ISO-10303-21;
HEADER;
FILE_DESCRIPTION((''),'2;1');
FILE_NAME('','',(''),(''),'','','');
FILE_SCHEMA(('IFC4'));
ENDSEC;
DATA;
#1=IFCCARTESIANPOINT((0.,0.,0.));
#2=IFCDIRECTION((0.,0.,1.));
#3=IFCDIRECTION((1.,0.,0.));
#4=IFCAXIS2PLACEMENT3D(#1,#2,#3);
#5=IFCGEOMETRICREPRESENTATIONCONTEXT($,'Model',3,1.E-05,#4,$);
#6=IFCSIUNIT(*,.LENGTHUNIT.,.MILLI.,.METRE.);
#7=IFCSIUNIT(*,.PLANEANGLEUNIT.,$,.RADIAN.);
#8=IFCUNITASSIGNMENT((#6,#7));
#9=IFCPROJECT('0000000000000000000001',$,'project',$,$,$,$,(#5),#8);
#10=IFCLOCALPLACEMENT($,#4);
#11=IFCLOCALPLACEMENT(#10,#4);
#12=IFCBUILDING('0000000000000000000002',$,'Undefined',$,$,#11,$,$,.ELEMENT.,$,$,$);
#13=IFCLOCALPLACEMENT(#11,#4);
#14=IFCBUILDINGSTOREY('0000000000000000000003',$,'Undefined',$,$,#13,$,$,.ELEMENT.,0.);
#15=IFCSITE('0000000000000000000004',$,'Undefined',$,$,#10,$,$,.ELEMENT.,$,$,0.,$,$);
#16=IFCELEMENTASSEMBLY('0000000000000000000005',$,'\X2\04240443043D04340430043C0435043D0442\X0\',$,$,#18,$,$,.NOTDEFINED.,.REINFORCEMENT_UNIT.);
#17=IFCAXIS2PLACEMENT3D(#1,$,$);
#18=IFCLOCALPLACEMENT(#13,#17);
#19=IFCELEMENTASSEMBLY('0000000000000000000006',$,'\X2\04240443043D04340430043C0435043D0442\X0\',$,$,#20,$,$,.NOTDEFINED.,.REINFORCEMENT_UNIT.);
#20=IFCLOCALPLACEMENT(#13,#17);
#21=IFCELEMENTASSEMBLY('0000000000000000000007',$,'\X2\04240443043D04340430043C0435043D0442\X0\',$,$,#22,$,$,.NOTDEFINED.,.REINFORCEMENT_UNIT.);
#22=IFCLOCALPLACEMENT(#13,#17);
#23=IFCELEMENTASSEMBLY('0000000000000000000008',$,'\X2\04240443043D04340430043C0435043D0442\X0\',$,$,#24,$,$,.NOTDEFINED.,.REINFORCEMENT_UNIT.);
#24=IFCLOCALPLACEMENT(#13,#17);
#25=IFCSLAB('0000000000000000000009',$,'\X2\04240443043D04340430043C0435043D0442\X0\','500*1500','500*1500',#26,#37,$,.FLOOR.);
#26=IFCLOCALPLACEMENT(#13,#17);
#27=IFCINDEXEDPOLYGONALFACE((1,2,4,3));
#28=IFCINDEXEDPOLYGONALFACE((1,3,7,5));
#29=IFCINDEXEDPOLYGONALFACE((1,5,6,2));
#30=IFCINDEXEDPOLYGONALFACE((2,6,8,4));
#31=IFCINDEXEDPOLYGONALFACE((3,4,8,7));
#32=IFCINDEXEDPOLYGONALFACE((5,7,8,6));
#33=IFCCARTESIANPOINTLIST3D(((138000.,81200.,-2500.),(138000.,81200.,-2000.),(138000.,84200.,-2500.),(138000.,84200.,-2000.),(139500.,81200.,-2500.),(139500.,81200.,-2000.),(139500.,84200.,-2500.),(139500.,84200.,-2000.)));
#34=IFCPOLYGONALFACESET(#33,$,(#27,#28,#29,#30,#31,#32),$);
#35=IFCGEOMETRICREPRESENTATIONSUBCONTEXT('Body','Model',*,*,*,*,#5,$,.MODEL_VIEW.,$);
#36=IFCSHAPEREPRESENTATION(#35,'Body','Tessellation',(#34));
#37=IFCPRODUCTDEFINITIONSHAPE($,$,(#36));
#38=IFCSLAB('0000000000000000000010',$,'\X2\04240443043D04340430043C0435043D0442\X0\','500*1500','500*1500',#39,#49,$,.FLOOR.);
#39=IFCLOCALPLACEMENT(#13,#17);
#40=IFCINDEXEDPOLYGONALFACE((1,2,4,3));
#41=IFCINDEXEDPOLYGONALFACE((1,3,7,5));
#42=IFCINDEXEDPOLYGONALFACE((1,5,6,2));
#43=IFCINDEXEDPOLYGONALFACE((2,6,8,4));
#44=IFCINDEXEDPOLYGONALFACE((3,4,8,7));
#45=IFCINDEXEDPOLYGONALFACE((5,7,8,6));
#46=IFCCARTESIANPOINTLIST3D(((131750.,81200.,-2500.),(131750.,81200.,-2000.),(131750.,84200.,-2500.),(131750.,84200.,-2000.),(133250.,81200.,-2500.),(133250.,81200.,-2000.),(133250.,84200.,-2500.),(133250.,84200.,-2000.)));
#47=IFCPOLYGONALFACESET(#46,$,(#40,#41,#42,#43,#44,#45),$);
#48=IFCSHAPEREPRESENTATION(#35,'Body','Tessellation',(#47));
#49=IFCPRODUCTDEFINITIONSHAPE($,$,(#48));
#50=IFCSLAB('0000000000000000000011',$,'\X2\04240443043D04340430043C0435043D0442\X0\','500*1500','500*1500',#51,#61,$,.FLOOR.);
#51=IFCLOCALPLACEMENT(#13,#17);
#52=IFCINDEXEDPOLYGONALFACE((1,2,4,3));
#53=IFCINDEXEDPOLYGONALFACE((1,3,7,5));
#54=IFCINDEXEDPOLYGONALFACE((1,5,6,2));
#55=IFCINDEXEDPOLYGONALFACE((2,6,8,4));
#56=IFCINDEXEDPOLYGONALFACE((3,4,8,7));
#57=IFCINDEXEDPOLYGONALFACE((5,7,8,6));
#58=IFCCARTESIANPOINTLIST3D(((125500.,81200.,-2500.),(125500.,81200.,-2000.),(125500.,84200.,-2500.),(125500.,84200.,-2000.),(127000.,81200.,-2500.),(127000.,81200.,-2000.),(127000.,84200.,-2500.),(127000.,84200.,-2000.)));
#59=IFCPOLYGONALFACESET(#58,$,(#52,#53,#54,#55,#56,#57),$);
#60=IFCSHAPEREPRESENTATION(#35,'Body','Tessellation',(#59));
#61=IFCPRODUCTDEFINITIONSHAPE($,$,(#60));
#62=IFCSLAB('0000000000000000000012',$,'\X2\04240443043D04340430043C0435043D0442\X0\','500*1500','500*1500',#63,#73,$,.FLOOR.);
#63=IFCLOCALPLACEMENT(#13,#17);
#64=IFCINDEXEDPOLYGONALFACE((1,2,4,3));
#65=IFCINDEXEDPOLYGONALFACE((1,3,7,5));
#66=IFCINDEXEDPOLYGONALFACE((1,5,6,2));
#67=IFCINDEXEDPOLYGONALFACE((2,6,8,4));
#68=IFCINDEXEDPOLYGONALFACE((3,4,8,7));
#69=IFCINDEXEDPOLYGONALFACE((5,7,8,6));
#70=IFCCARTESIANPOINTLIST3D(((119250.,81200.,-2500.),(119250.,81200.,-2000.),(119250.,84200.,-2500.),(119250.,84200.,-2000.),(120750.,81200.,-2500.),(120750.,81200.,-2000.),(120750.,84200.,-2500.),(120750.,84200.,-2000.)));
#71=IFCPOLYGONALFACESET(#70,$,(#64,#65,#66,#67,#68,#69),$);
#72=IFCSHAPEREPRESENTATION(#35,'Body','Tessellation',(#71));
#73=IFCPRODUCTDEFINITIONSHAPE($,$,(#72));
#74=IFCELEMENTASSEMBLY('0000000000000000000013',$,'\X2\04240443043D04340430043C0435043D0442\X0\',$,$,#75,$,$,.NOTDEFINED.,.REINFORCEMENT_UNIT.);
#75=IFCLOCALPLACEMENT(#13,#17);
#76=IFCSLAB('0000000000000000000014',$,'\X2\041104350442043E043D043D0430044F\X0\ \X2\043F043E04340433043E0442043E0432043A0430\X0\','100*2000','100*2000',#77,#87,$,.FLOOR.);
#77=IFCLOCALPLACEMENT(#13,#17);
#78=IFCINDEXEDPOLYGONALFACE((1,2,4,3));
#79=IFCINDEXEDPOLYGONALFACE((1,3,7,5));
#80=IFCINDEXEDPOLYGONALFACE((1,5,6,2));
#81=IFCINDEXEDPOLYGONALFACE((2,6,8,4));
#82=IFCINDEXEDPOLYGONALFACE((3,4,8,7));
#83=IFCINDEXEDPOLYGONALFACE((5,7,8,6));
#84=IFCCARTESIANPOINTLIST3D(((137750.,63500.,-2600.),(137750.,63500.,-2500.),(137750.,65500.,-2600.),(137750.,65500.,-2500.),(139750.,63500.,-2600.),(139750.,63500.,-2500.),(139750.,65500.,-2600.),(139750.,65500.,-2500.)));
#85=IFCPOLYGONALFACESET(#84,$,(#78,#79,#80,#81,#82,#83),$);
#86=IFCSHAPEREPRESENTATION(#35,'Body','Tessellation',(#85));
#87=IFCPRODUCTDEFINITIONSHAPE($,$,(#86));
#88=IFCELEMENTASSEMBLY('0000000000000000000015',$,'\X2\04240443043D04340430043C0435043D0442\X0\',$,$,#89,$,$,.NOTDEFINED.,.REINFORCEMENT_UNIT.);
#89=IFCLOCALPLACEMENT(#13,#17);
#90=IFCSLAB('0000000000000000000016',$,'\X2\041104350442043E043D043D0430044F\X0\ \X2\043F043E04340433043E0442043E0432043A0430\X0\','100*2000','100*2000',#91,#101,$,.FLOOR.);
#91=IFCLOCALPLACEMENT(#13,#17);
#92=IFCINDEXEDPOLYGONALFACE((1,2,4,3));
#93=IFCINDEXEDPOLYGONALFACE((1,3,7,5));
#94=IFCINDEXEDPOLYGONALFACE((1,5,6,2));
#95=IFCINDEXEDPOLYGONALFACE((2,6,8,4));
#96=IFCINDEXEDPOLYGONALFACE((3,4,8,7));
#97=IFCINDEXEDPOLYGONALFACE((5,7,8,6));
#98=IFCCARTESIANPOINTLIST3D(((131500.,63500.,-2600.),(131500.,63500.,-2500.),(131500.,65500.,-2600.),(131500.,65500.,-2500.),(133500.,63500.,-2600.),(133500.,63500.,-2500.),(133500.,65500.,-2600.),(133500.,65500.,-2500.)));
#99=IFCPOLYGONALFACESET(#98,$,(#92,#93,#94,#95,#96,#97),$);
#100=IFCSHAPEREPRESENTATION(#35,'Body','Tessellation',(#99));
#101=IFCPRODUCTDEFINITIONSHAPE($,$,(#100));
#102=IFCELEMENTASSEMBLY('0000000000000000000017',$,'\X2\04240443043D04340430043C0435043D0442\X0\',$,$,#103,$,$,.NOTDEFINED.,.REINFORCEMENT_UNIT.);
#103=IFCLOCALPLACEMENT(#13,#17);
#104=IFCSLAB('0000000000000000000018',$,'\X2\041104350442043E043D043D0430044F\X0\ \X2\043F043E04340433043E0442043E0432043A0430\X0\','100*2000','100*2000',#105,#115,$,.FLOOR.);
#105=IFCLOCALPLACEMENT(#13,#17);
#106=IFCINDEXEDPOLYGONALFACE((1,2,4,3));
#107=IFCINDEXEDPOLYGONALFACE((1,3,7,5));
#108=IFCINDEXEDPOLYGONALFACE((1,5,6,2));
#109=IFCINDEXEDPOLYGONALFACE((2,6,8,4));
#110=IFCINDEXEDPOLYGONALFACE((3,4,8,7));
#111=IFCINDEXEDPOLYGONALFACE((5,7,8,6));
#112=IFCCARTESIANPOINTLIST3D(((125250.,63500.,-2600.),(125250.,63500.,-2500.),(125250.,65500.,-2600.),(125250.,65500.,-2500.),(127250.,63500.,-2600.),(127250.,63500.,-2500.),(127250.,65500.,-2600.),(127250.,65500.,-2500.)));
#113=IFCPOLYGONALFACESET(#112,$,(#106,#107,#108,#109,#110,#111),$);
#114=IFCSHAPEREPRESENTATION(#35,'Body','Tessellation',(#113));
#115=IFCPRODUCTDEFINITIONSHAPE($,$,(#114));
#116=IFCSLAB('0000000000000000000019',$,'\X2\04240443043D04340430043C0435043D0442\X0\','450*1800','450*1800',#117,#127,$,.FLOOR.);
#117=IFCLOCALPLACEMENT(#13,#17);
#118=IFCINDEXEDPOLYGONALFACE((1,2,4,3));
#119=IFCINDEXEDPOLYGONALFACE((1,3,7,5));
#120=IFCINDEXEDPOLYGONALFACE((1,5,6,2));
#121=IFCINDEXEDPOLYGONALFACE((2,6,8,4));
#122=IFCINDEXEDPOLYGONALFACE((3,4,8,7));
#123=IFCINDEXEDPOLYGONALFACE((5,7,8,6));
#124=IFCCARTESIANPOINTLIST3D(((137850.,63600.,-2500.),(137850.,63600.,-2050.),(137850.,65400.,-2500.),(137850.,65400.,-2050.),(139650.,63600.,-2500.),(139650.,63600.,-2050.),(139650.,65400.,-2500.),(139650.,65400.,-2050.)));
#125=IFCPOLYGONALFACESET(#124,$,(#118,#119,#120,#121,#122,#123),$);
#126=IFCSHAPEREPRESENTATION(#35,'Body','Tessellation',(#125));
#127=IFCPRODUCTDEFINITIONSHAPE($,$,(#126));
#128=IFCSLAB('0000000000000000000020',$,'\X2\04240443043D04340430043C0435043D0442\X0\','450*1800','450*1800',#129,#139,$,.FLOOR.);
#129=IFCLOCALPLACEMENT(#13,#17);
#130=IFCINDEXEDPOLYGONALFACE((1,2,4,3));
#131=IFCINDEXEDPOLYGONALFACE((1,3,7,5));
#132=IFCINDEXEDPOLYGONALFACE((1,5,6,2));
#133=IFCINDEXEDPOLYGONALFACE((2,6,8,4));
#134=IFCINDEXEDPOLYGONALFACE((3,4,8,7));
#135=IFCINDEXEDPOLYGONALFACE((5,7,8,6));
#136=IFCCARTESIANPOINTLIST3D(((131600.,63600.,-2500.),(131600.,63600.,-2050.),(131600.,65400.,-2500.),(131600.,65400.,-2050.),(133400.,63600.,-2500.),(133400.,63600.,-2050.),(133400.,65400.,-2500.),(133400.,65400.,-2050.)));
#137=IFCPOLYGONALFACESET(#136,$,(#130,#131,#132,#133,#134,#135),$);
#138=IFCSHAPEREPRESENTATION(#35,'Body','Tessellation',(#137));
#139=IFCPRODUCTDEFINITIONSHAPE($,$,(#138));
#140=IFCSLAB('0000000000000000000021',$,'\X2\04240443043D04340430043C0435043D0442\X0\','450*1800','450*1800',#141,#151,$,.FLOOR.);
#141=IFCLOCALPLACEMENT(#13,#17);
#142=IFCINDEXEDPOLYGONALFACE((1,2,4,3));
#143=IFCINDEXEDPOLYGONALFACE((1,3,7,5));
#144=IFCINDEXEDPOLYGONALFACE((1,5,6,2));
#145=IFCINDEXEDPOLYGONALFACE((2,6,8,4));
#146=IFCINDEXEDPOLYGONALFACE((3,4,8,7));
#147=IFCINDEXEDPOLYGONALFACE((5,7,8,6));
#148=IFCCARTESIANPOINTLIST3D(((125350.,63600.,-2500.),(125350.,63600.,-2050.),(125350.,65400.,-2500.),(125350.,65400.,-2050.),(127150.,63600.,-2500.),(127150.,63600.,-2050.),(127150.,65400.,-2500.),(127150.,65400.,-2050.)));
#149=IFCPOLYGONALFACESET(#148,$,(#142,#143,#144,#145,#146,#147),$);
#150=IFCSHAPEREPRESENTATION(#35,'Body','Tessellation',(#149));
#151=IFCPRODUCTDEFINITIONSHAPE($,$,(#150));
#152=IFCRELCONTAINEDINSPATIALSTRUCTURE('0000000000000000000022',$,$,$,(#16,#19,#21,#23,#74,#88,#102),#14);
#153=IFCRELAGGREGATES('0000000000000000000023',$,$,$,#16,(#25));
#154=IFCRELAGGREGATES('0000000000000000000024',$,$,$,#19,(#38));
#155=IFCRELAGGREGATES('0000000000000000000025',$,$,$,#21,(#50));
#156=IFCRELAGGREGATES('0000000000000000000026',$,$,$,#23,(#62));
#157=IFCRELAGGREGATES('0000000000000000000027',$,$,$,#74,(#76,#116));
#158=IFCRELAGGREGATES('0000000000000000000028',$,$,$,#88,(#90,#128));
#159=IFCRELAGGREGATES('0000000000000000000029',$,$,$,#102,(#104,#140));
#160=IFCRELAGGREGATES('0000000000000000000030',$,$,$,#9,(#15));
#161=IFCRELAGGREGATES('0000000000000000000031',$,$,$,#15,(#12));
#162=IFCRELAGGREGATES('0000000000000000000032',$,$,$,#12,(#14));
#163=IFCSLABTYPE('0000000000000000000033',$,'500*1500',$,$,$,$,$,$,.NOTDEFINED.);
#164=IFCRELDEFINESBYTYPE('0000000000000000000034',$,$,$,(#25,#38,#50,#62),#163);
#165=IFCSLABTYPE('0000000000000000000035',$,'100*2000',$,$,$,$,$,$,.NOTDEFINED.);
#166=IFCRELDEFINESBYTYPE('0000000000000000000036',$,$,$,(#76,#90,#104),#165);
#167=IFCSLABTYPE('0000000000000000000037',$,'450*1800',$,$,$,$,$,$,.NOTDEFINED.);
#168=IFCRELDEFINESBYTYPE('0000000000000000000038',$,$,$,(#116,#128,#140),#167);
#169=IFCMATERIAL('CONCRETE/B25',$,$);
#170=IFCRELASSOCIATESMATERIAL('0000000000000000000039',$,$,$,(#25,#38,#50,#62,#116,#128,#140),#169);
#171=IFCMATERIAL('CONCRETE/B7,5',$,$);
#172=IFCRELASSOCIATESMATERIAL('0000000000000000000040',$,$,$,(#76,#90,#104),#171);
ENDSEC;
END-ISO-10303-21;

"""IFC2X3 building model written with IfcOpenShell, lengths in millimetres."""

from ifc_helpers import new_model, si_unit, frame, origin_with_axes, place, context, subcontext, project, spatial, polyline, outline, extrude, material, type_object, element, aggregate, save


model = new_model("IFC2X3")

# Units and contexts
model_context = context("Model", 3, precision=1e-05, world=origin_with_axes())
body_context = subcontext(model_context, "Body", "Model", "MODEL_VIEW")
ifc_project = project(units=[si_unit("LENGTHUNIT", "METRE", prefix="MILLI"), si_unit("PLANEANGLEUNIT", "RADIAN")], contexts=[model_context])

# Site, building, storey
site_placement = place(None, origin_with_axes())
site = spatial("IfcSite", under=ifc_project, at=site_placement, Name="Undefined", CompositionType="ELEMENT", RefElevation=0.0)
building_placement = place(site_placement, origin_with_axes())
building = spatial("IfcBuilding", under=site, at=building_placement, Name="Undefined", CompositionType="ELEMENT")
storey_placement = place(building_placement, origin_with_axes())
storey = spatial("IfcBuildingStorey", under=building, at=storey_placement, Name="Undefined", CompositionType="ELEMENT", Elevation=0.0)

# Element assemblies
assembly_1_placement = place(storey_placement, origin_with_axes())
assembly_1 = element("IfcElementAssembly", 1, at=assembly_1_placement, inside=storey, Name="Фундамент", AssemblyPlace="NOTDEFINED", PredefinedType="REINFORCEMENT_UNIT")
ifc_material_1 = material(Name="CONCRETE/B25")
assembly_2_placement = place(storey_placement, origin_with_axes())
assembly_2 = element("IfcElementAssembly", 2, at=assembly_2_placement, inside=storey, Name="Фундамент", AssemblyPlace="NOTDEFINED", PredefinedType="REINFORCEMENT_UNIT")
assembly_3_placement = place(storey_placement, origin_with_axes())
assembly_3 = element("IfcElementAssembly", 3, at=assembly_3_placement, inside=storey, Name="Фундамент", AssemblyPlace="NOTDEFINED", PredefinedType="REINFORCEMENT_UNIT")
assembly_4_placement = place(storey_placement, origin_with_axes())
assembly_4 = element("IfcElementAssembly", 4, at=assembly_4_placement, inside=storey, Name="Фундамент", AssemblyPlace="NOTDEFINED", PredefinedType="REINFORCEMENT_UNIT")

# Slabs
ifc_material_2 = material(Name="CONCRETE/B7,5")
slab_type_1 = type_object("IfcSlabType", Name="500*1500", PredefinedType="NOTDEFINED")
slab_1_placement = place(assembly_1_placement, frame((138000.0, 84200.0, -2250.0), z_axis=(0.0, 0.0, 1.0), x_axis=(0.0, -1.0, 0.0)))
slab_1 = element("IfcSlab", 5, at=slab_1_placement, type_object=slab_type_1, material=ifc_material_1, Name="Фундамент", Description="500*1500", ObjectType="500*1500", PredefinedType="FLOOR", context=body_context, shape_type="SweptSolid", body=[
    extrude(outline(polyline([(0.0, 0.0), (3000.0, 0.0), (3000.0, 1500.0), (0.0, 1500.0), (0.0, 0.0)])), frame((0.0, 0.0, -250.0), z_axis=(0.0, 0.0, 1.0), x_axis=(1.0, 0.0, 0.0)), (0.0, 0.0, 1.0), 500.0),
])
aggregate(assembly_1, [slab_1])
slab_2_placement = place(assembly_2_placement, frame((131750.0, 84200.0, -2250.0), z_axis=(0.0, 0.0, 1.0), x_axis=(0.0, -1.0, 0.0)))
slab_2 = element("IfcSlab", 6, at=slab_2_placement, type_object=slab_type_1, material=ifc_material_1, Name="Фундамент", Description="500*1500", ObjectType="500*1500", PredefinedType="FLOOR", context=body_context, shape_type="SweptSolid", body=[
    extrude(outline(polyline([(0.0, 0.0), (3000.0, 0.0), (3000.0, 1500.0), (0.0, 1500.0), (0.0, 0.0)])), frame((0.0, 0.0, -250.0), z_axis=(0.0, 0.0, 1.0), x_axis=(1.0, 0.0, 0.0)), (0.0, 0.0, 1.0), 500.0),
])
aggregate(assembly_2, [slab_2])
slab_3_placement = place(assembly_3_placement, frame((125500.0, 84200.0, -2250.0), z_axis=(0.0, 0.0, 1.0), x_axis=(0.0, -1.0, 0.0)))
slab_3 = element("IfcSlab", 7, at=slab_3_placement, type_object=slab_type_1, material=ifc_material_1, Name="Фундамент", Description="500*1500", ObjectType="500*1500", PredefinedType="FLOOR", context=body_context, shape_type="SweptSolid", body=[
    extrude(outline(polyline([(0.0, 0.0), (3000.0, 0.0), (3000.0, 1500.0), (0.0, 1500.0), (0.0, 0.0)])), frame((0.0, 0.0, -250.0), z_axis=(0.0, 0.0, 1.0), x_axis=(1.0, 0.0, 0.0)), (0.0, 0.0, 1.0), 500.0),
])
aggregate(assembly_3, [slab_3])
slab_4_placement = place(assembly_4_placement, frame((119250.0, 84200.0, -2250.0), z_axis=(0.0, 0.0, 1.0), x_axis=(0.0, -1.0, 0.0)))
slab_4 = element("IfcSlab", 8, at=slab_4_placement, type_object=slab_type_1, material=ifc_material_1, Name="Фундамент", Description="500*1500", ObjectType="500*1500", PredefinedType="FLOOR", context=body_context, shape_type="SweptSolid", body=[
    extrude(outline(polyline([(0.0, 0.0), (3000.0, 0.0), (3000.0, 1500.0), (0.0, 1500.0), (0.0, 0.0)])), frame((0.0, 0.0, -250.0), z_axis=(0.0, 0.0, 1.0), x_axis=(1.0, 0.0, 0.0)), (0.0, 0.0, 1.0), 500.0),
])
aggregate(assembly_4, [slab_4])

# Element assemblies, slabs
assembly_5_placement = place(storey_placement, origin_with_axes())
assembly_5 = element("IfcElementAssembly", 9, at=assembly_5_placement, inside=storey, Name="Фундамент", AssemblyPlace="NOTDEFINED", PredefinedType="REINFORCEMENT_UNIT")
slab_type_2 = type_object("IfcSlabType", Name="100*2000", PredefinedType="NOTDEFINED")
slab_5_placement = place(assembly_5_placement, frame((137750.0, 65500.0, -2550.0), z_axis=(0.0, 0.0, 1.0), x_axis=(0.0, -1.0, 0.0)))
slab_5 = element("IfcSlab", 10, at=slab_5_placement, type_object=slab_type_2, material=ifc_material_2, Name="Бетонная подготовка", Description="100*2000", ObjectType="100*2000", PredefinedType="FLOOR", context=body_context, shape_type="SweptSolid", body=[
    extrude(outline(polyline([(0.0, 0.0), (2000.0, 0.0), (2000.0, 2000.0), (0.0, 2000.0), (0.0, 0.0)])), frame((0.0, 0.0, -50.0), z_axis=(0.0, 0.0, 1.0), x_axis=(1.0, 0.0, 0.0)), (0.0, 0.0, 1.0), 100.0),
])
assembly_6_placement = place(storey_placement, origin_with_axes())
assembly_6 = element("IfcElementAssembly", 11, at=assembly_6_placement, inside=storey, Name="Фундамент", AssemblyPlace="NOTDEFINED", PredefinedType="REINFORCEMENT_UNIT")
slab_6_placement = place(assembly_6_placement, frame((131500.0, 65500.0, -2550.0), z_axis=(0.0, 0.0, 1.0), x_axis=(0.0, -1.0, 0.0)))
slab_6 = element("IfcSlab", 12, at=slab_6_placement, type_object=slab_type_2, material=ifc_material_2, Name="Бетонная подготовка", Description="100*2000", ObjectType="100*2000", PredefinedType="FLOOR", context=body_context, shape_type="SweptSolid", body=[
    extrude(outline(polyline([(0.0, 0.0), (2000.0, 0.0), (2000.0, 2000.0), (0.0, 2000.0), (0.0, 0.0)])), frame((0.0, 0.0, -50.0), z_axis=(0.0, 0.0, 1.0), x_axis=(1.0, 0.0, 0.0)), (0.0, 0.0, 1.0), 100.0),
])
assembly_7_placement = place(storey_placement, origin_with_axes())
assembly_7 = element("IfcElementAssembly", 13, at=assembly_7_placement, inside=storey, Name="Фундамент", AssemblyPlace="NOTDEFINED", PredefinedType="REINFORCEMENT_UNIT")
slab_7_placement = place(assembly_7_placement, frame((125250.0, 65500.0, -2550.0), z_axis=(0.0, 0.0, 1.0), x_axis=(0.0, -1.0, 0.0)))
slab_7 = element("IfcSlab", 14, at=slab_7_placement, type_object=slab_type_2, material=ifc_material_2, Name="Бетонная подготовка", Description="100*2000", ObjectType="100*2000", PredefinedType="FLOOR", context=body_context, shape_type="SweptSolid", body=[
    extrude(outline(polyline([(0.0, 0.0), (2000.0, 0.0), (2000.0, 2000.0), (0.0, 2000.0), (0.0, 0.0)])), frame((0.0, 0.0, -50.0), z_axis=(0.0, 0.0, 1.0), x_axis=(1.0, 0.0, 0.0)), (0.0, 0.0, 1.0), 100.0),
])

# Slabs
slab_type_3 = type_object("IfcSlabType", Name="450*1800", PredefinedType="NOTDEFINED")
slab_8_placement = place(assembly_5_placement, frame((137850.0, 65400.0, -2275.0), z_axis=(0.0, 0.0, 1.0), x_axis=(0.0, -1.0, 0.0)))
slab_8 = element("IfcSlab", 15, at=slab_8_placement, type_object=slab_type_3, material=ifc_material_1, Name="Фундамент", Description="450*1800", ObjectType="450*1800", PredefinedType="FLOOR", context=body_context, shape_type="SweptSolid", body=[
    extrude(outline(polyline([(0.0, 0.0), (1800.0, 0.0), (1800.0, 1800.0), (0.0, 1800.0), (0.0, 0.0)])), frame((0.0, 0.0, -225.0), z_axis=(0.0, 0.0, 1.0), x_axis=(1.0, 0.0, 0.0)), (0.0, 0.0, 1.0), 450.0),
])
aggregate(assembly_5, [slab_5, slab_8])
slab_9_placement = place(assembly_6_placement, frame((131600.0, 65400.0, -2275.0), z_axis=(0.0, 0.0, 1.0), x_axis=(0.0, -1.0, 0.0)))
slab_9 = element("IfcSlab", 16, at=slab_9_placement, type_object=slab_type_3, material=ifc_material_1, Name="Фундамент", Description="450*1800", ObjectType="450*1800", PredefinedType="FLOOR", context=body_context, shape_type="SweptSolid", body=[
    extrude(outline(polyline([(0.0, 0.0), (1800.0, 0.0), (1800.0, 1800.0), (0.0, 1800.0), (0.0, 0.0)])), frame((0.0, 0.0, -225.0), z_axis=(0.0, 0.0, 1.0), x_axis=(1.0, 0.0, 0.0)), (0.0, 0.0, 1.0), 450.0),
])
aggregate(assembly_6, [slab_6, slab_9])
slab_10_placement = place(assembly_7_placement, frame((125350.0, 65400.0, -2275.0), z_axis=(0.0, 0.0, 1.0), x_axis=(0.0, -1.0, 0.0)))
slab_10 = element("IfcSlab", 17, at=slab_10_placement, type_object=slab_type_3, material=ifc_material_1, Name="Фундамент", Description="450*1800", ObjectType="450*1800", PredefinedType="FLOOR", context=body_context, shape_type="SweptSolid", body=[
    extrude(outline(polyline([(0.0, 0.0), (1800.0, 0.0), (1800.0, 1800.0), (0.0, 1800.0), (0.0, 0.0)])), frame((0.0, 0.0, -225.0), z_axis=(0.0, 0.0, 1.0), x_axis=(1.0, 0.0, 0.0)), (0.0, 0.0, 1.0), 450.0),
])
aggregate(assembly_7, [slab_7, slab_10])

save(model, "model.ifc")
